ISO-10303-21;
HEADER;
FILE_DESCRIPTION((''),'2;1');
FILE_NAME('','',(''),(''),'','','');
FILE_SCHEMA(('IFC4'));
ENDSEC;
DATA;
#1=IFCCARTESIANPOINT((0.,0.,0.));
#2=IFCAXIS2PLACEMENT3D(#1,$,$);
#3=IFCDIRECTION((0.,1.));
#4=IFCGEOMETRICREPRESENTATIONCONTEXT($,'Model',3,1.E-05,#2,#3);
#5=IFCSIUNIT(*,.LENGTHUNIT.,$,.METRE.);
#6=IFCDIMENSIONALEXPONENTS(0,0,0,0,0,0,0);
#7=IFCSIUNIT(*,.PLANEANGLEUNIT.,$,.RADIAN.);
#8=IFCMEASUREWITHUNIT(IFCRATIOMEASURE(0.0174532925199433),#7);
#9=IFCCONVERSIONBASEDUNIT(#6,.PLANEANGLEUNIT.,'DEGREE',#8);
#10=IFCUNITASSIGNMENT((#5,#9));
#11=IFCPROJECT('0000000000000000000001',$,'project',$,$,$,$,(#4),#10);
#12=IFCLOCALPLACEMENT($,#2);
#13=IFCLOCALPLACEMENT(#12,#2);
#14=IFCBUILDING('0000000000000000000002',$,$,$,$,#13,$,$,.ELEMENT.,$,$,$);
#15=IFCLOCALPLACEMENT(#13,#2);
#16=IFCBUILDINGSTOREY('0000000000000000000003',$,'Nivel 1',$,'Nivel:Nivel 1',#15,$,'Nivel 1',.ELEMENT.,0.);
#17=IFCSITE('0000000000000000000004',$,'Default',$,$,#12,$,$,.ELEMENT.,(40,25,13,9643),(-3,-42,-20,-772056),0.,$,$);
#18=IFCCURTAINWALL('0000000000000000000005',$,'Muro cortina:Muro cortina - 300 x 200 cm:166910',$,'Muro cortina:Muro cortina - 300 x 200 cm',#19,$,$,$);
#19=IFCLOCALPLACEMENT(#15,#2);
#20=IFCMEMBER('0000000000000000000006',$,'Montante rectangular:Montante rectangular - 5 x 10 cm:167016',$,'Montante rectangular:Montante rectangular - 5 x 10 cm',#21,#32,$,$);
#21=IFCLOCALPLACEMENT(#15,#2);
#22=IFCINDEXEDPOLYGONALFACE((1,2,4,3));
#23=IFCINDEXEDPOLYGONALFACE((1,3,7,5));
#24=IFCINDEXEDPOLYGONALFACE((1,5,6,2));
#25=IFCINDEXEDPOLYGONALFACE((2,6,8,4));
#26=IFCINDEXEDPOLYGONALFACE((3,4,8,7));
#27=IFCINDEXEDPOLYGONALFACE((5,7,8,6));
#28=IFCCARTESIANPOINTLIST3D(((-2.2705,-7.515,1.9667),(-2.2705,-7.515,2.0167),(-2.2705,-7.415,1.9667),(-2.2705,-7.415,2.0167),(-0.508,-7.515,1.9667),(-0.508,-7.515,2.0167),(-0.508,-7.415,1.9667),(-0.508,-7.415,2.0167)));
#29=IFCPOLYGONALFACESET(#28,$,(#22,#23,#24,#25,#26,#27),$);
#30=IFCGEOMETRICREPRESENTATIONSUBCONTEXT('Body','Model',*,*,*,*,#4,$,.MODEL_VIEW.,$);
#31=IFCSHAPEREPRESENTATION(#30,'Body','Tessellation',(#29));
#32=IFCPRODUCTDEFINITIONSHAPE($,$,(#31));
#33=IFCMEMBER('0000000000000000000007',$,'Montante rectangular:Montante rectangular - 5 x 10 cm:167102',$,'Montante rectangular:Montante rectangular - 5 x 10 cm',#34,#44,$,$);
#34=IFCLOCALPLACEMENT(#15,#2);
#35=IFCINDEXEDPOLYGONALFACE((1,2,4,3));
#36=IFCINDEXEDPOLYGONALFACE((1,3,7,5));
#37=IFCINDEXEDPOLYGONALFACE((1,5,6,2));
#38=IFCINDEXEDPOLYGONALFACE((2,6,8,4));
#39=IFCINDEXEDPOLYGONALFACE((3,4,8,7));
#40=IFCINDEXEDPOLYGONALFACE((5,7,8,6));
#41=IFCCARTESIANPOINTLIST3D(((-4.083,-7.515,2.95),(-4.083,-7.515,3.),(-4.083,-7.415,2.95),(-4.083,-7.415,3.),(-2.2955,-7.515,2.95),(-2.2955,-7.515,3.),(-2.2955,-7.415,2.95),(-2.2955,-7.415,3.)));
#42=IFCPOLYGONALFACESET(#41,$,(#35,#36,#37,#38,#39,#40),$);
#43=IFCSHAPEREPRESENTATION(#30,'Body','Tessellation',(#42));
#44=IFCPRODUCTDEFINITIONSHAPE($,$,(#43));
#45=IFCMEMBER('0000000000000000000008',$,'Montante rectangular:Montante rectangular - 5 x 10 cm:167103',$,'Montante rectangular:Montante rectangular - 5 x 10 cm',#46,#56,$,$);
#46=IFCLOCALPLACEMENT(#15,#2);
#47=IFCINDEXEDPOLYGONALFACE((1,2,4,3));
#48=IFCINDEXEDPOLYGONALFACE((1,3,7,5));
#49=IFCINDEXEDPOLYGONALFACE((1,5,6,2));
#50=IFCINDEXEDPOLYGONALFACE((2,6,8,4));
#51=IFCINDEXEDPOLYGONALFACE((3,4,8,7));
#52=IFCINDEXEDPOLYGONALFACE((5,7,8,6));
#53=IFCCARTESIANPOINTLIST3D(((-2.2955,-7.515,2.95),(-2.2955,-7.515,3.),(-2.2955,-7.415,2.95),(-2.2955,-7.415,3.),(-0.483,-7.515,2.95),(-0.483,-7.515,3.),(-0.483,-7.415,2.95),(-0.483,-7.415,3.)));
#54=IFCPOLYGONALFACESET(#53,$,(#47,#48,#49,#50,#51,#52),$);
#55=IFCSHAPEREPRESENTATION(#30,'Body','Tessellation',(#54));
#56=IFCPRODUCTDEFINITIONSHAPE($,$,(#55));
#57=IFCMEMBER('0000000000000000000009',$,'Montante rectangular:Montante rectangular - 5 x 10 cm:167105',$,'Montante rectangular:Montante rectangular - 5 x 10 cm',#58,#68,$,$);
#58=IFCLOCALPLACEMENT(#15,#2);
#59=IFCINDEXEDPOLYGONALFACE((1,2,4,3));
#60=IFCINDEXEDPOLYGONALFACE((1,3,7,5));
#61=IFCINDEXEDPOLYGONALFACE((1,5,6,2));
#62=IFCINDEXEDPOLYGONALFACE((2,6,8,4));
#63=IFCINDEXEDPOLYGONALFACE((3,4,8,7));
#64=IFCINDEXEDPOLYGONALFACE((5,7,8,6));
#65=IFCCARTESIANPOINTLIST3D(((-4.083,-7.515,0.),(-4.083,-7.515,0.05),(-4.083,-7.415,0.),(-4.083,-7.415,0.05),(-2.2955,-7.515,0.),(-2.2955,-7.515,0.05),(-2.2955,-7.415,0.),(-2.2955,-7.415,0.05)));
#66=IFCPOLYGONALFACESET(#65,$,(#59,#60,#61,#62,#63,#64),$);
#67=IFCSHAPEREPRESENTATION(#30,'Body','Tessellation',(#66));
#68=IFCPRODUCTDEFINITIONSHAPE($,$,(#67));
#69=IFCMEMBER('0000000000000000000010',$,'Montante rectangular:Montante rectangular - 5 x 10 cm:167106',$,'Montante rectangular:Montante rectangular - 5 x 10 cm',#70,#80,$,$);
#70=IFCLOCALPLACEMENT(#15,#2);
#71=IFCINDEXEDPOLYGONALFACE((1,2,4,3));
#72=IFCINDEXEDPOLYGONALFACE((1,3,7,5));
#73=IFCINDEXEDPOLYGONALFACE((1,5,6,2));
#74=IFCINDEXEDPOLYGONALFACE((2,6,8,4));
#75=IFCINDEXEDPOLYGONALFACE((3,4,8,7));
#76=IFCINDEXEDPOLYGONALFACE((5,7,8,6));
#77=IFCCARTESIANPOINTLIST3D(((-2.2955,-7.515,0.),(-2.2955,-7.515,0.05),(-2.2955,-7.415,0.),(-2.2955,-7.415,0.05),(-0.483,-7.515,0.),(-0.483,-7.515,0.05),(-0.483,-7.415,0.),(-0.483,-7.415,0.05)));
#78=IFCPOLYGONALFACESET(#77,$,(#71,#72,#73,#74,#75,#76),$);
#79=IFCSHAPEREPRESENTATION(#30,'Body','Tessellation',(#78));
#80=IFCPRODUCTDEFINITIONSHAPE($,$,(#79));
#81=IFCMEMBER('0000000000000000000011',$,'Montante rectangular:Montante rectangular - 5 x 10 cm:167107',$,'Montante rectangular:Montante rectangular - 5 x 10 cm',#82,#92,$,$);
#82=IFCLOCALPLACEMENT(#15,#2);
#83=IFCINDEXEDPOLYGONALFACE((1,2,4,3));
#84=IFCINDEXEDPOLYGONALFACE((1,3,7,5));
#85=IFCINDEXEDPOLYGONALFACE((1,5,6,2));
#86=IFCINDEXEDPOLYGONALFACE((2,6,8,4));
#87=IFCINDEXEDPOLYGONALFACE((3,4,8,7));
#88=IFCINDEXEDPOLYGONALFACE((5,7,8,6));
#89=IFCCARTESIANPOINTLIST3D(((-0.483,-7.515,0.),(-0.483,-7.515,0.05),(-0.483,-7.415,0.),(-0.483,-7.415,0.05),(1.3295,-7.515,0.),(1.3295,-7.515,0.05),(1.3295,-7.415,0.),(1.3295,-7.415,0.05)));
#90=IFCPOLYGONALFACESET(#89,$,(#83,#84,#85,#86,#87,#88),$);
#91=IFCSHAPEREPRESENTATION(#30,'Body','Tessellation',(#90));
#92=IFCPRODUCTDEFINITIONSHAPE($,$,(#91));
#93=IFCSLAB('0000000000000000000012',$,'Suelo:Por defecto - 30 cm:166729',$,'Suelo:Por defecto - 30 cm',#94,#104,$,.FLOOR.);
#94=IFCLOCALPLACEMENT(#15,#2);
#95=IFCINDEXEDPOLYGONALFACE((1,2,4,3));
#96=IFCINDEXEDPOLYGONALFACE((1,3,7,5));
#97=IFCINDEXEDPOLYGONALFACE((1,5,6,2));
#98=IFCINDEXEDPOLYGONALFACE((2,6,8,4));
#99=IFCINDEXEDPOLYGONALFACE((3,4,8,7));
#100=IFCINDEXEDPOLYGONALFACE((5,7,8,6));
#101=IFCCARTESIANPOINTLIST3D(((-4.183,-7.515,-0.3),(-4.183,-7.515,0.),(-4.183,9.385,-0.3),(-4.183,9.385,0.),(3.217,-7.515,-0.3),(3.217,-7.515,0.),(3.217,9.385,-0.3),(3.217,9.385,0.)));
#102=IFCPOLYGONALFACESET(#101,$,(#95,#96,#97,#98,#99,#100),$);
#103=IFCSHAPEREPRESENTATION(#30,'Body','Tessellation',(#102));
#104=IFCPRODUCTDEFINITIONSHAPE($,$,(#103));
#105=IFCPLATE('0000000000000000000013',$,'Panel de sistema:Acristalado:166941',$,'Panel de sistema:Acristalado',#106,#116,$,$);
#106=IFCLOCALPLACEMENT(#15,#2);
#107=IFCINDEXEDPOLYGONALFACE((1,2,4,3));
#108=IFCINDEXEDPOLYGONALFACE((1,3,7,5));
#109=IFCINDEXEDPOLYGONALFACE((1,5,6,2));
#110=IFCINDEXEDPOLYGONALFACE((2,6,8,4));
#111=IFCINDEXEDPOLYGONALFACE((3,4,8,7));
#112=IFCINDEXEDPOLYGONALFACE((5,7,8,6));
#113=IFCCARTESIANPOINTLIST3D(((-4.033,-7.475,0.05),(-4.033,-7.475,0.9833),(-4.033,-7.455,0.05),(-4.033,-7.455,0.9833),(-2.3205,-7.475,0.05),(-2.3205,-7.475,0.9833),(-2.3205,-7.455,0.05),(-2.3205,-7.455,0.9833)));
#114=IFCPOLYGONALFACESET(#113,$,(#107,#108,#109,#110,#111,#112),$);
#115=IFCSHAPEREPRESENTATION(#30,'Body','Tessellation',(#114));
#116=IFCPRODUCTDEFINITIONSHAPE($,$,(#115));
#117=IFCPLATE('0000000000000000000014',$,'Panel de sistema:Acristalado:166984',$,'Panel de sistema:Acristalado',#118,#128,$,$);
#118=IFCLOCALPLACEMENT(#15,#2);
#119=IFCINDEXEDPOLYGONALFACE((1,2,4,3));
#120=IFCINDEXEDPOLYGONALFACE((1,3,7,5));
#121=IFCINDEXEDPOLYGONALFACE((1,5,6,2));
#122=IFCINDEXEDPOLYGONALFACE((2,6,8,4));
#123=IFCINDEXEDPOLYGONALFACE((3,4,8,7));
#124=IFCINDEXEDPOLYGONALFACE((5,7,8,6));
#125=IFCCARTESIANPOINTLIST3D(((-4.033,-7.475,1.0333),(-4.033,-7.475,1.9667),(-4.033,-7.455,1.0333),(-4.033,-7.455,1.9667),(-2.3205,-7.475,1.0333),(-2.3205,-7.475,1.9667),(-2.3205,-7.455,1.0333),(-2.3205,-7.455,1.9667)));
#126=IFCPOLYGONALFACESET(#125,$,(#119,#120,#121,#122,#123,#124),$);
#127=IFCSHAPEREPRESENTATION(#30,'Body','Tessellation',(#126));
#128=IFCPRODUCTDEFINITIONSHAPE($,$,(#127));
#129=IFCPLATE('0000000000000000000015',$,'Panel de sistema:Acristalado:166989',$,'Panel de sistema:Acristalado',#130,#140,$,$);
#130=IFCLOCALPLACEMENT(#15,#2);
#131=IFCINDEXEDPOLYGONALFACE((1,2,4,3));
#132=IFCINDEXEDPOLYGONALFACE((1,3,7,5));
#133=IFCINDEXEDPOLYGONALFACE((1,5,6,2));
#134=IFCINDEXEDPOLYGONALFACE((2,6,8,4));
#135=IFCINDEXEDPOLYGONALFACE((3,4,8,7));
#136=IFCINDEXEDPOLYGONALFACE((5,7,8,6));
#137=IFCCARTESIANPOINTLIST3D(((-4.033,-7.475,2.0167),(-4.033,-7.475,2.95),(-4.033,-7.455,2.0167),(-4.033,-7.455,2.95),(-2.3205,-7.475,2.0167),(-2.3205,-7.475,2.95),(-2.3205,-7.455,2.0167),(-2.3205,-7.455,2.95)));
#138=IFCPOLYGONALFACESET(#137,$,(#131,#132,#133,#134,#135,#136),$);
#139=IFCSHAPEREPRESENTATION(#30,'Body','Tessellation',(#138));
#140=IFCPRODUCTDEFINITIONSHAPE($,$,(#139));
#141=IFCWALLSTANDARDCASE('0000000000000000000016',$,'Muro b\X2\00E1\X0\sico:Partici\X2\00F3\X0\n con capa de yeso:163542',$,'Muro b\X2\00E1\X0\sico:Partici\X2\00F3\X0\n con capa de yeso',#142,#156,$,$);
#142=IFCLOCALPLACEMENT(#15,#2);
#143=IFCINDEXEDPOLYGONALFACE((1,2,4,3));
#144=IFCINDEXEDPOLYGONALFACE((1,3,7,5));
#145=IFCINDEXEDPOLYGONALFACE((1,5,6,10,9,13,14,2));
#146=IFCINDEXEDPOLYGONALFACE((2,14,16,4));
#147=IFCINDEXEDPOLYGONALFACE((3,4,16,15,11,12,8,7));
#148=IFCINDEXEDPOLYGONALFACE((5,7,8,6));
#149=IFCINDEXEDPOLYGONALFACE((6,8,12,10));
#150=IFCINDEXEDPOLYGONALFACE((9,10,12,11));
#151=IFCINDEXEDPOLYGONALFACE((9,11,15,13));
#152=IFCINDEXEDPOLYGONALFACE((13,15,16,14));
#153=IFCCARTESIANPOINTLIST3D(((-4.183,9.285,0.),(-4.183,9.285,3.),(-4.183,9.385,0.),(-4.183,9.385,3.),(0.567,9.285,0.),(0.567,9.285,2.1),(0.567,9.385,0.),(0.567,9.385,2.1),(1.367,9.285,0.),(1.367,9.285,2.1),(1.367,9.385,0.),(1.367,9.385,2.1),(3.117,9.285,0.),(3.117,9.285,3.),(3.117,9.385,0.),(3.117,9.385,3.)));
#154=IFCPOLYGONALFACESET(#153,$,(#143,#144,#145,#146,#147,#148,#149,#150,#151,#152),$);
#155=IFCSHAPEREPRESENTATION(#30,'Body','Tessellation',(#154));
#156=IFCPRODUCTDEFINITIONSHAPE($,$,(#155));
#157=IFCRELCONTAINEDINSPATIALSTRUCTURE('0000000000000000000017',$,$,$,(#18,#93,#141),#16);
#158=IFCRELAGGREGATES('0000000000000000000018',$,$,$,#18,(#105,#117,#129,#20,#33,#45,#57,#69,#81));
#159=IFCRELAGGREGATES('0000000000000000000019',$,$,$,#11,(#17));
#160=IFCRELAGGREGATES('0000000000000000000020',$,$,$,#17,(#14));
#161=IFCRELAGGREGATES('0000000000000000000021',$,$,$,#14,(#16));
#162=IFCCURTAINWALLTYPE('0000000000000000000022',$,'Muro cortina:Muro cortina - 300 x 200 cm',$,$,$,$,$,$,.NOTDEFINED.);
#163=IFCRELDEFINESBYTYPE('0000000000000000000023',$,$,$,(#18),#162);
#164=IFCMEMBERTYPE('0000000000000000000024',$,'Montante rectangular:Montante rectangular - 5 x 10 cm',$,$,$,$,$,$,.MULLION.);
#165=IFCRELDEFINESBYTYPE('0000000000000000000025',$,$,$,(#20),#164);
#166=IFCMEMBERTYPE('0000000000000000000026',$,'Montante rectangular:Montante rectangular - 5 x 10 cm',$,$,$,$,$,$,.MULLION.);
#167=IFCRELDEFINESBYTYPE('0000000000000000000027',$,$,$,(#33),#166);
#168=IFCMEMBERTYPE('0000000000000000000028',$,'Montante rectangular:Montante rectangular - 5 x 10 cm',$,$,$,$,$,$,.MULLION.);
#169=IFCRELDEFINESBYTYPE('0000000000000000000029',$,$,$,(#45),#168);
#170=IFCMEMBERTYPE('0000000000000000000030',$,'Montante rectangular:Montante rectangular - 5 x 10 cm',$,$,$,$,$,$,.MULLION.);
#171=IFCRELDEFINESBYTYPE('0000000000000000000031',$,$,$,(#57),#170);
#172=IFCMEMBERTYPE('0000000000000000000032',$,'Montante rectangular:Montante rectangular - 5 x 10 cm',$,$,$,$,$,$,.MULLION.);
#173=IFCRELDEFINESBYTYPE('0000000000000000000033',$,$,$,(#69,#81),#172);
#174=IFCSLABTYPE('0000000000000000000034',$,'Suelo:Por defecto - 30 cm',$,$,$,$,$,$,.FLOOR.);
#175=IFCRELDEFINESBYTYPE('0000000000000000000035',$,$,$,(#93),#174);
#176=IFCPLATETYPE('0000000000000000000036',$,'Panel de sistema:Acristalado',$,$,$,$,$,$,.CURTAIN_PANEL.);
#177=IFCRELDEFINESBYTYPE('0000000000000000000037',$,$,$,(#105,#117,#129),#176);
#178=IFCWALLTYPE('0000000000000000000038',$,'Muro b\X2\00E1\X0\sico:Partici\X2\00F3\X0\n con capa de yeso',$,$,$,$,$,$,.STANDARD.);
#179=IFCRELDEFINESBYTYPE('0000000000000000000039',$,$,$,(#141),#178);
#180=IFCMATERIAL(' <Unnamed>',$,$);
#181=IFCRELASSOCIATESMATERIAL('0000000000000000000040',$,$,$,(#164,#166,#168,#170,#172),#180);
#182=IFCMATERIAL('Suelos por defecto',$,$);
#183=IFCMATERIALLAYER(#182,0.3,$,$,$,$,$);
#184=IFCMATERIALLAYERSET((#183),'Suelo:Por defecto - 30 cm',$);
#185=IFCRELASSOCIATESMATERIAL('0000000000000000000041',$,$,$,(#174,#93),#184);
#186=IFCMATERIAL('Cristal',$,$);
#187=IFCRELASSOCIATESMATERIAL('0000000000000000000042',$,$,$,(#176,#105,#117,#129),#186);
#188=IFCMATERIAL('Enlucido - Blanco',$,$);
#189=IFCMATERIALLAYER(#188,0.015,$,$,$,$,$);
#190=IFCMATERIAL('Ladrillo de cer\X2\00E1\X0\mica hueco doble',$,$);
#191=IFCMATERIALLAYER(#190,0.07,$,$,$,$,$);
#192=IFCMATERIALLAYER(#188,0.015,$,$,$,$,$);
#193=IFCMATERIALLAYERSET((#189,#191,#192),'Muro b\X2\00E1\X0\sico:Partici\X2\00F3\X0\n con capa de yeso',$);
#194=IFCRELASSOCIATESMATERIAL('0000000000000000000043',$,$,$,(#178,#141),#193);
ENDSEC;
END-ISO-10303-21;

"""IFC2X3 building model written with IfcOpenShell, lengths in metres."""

from ifc_helpers import new_model, entity, si_unit, converted_unit, direction, frame, frame_2d, origin, origin_2d_with_axis, place, context, subcontext, project, spatial, rectangle, extrude, source, transform, mapped, material, layer, layer_set, layer_usage, type_object, type_shapes, element, aggregate, save


model = new_model("IFC2X3")

# Units and contexts
model_context = context("Model", 3, precision=1e-05, world=origin(), true_north=direction((0.0, 1.0)))
body_context = subcontext(model_context, "Body", "Model", "MODEL_VIEW")
ifc_project = project(units=[si_unit("LENGTHUNIT", "METRE"), converted_unit("PLANEANGLEUNIT", "DEGREE", entity("IfcRatioMeasure", 0.0174532925199433), si_unit("PLANEANGLEUNIT", "RADIAN"), dimensions=[0, 0, 0, 0, 0, 0, 0])], contexts=[model_context])

# Site, building, storey
site_placement = place(None, origin())
site = spatial("IfcSite", under=ifc_project, at=site_placement, Name="Default", CompositionType="ELEMENT", RefLatitude=(40, 25, 13, 9643), RefLongitude=(-3, -42, -20, -772056), RefElevation=0.0)
building_placement = place(site_placement, origin())
building = spatial("IfcBuilding", under=site, at=building_placement, CompositionType="ELEMENT")
storey_placement = place(building_placement, origin())
storey = spatial("IfcBuildingStorey", under=building, at=storey_placement, Name="Nivel 1", ObjectType="Nivel:Nivel 1", LongName="Nivel 1", CompositionType="ELEMENT", Elevation=0.0)

# Curtain wall, members
curtain_wall_type = type_object("IfcCurtainWallType", Name="Muro cortina:Muro cortina - 300 x 200 cm", PredefinedType="NOTDEFINED")
curtain_wall_placement = place(storey_placement, origin())
curtain_wall = element("IfcCurtainWall", 1, at=curtain_wall_placement, inside=storey, type_object=curtain_wall_type, Name="Muro cortina:Muro cortina - 300 x 200 cm:166910", ObjectType="Muro cortina:Muro cortina - 300 x 200 cm")
ifc_material_1 = material(Name=" <Unnamed>")
member_type_1 = type_object("IfcMemberType", Name="Montante rectangular:Montante rectangular - 5 x 10 cm", PredefinedType="MULLION", material=ifc_material_1)
shared_shape_1 = source(origin(), body_context, "Body", "SweptSolid", [
    extrude(rectangle(XDim=0.1, YDim=0.05, at=origin_2d_with_axis()), frame((0.0, 0.0, -1.7625), z_axis=(0.0, 0.0, 1.0), x_axis=(0.0, -1.0, 0.0)), (0.0, 0.0, 1.0), 1.7625),
])
type_shapes(member_type_1, [shared_shape_1])
member_1_placement = place(storey_placement, frame((-0.508, -7.465, 1.9917), z_axis=(1.0, 0.0, 0.0), x_axis=(0.0, 0.0, 1.0)))
member_1 = element("IfcMember", 2, at=member_1_placement, type_object=member_type_1, Name="Montante rectangular:Montante rectangular - 5 x 10 cm:167016", ObjectType="Montante rectangular:Montante rectangular - 5 x 10 cm", context=body_context, shape_type="MappedRepresentation", body=[
    mapped(shared_shape_1, transform((0.0, 0.0, 0.0), scale=1.0)),
])
member_type_2 = type_object("IfcMemberType", Name="Montante rectangular:Montante rectangular - 5 x 10 cm", PredefinedType="MULLION", material=ifc_material_1)
shared_shape_2 = source(origin(), body_context, "Body", "SweptSolid", [
    extrude(rectangle(XDim=0.1, YDim=0.05, at=origin_2d_with_axis()), frame((-0.025, 0.0, -1.7875), z_axis=(0.0, 0.0, 1.0), x_axis=(0.0, -1.0, 0.0)), (0.0, 0.0, 1.0), 1.7875),
])
type_shapes(member_type_2, [shared_shape_2])
member_2_placement = place(storey_placement, frame((-2.2955, -7.465, 3.0), z_axis=(1.0, 0.0, 0.0), x_axis=(0.0, 0.0, 1.0)))
member_2 = element("IfcMember", 3, at=member_2_placement, type_object=member_type_2, Name="Montante rectangular:Montante rectangular - 5 x 10 cm:167102", ObjectType="Montante rectangular:Montante rectangular - 5 x 10 cm", context=body_context, shape_type="MappedRepresentation", body=[
    mapped(shared_shape_2, transform((0.0, 0.0, 0.0), scale=1.0)),
])
member_type_3 = type_object("IfcMemberType", Name="Montante rectangular:Montante rectangular - 5 x 10 cm", PredefinedType="MULLION", material=ifc_material_1)
shared_shape_3 = source(origin(), body_context, "Body", "SweptSolid", [
    extrude(rectangle(XDim=0.1, YDim=0.05, at=origin_2d_with_axis()), frame((-0.025, 0.0, -1.8125), z_axis=(0.0, 0.0, 1.0), x_axis=(0.0, -1.0, 0.0)), (0.0, 0.0, 1.0), 1.8125),
])
type_shapes(member_type_3, [shared_shape_3])
member_3_placement = place(storey_placement, frame((-0.483, -7.465, 3.0), z_axis=(1.0, 0.0, 0.0), x_axis=(0.0, 0.0, 1.0)))
member_3 = element("IfcMember", 4, at=member_3_placement, type_object=member_type_3, Name="Montante rectangular:Montante rectangular - 5 x 10 cm:167103", ObjectType="Montante rectangular:Montante rectangular - 5 x 10 cm", context=body_context, shape_type="MappedRepresentation", body=[
    mapped(shared_shape_3, transform((0.0, 0.0, 0.0), scale=1.0)),
])
member_type_4 = type_object("IfcMemberType", Name="Montante rectangular:Montante rectangular - 5 x 10 cm", PredefinedType="MULLION", material=ifc_material_1)
shared_shape_4 = source(origin(), body_context, "Body", "SweptSolid", [
    extrude(rectangle(XDim=0.1, YDim=0.05, at=origin_2d_with_axis()), frame((-0.025, 0.0, -1.7875), z_axis=(0.0, 0.0, 1.0), x_axis=(0.0, -1.0, 0.0)), (0.0, 0.0, 1.0), 1.7875),
])
type_shapes(member_type_4, [shared_shape_4])
member_4_placement = place(storey_placement, frame((-4.083, -7.465, 0.0), z_axis=(-1.0, 0.0, 0.0), x_axis=(0.0, 0.0, -1.0)))
member_4 = element("IfcMember", 5, at=member_4_placement, type_object=member_type_4, Name="Montante rectangular:Montante rectangular - 5 x 10 cm:167105", ObjectType="Montante rectangular:Montante rectangular - 5 x 10 cm", context=body_context, shape_type="MappedRepresentation", body=[
    mapped(shared_shape_4, transform((0.0, 0.0, 0.0), scale=1.0)),
])
member_type_5 = type_object("IfcMemberType", Name="Montante rectangular:Montante rectangular - 5 x 10 cm", PredefinedType="MULLION", material=ifc_material_1)
shared_shape_5 = source(origin(), body_context, "Body", "SweptSolid", [
    extrude(rectangle(XDim=0.1, YDim=0.05, at=origin_2d_with_axis()), frame((-0.025, 0.0, -1.8125), z_axis=(0.0, 0.0, 1.0), x_axis=(0.0, -1.0, 0.0)), (0.0, 0.0, 1.0), 1.8125),
])
type_shapes(member_type_5, [shared_shape_5])
member_5_placement = place(storey_placement, frame((-2.2955, -7.465, 0.0), z_axis=(-1.0, 0.0, 0.0), x_axis=(0.0, 0.0, -1.0)))
member_5 = element("IfcMember", 6, at=member_5_placement, type_object=member_type_5, Name="Montante rectangular:Montante rectangular - 5 x 10 cm:167106", ObjectType="Montante rectangular:Montante rectangular - 5 x 10 cm", context=body_context, shape_type="MappedRepresentation", body=[
    mapped(shared_shape_5, transform((0.0, 0.0, 0.0), scale=1.0)),
])
member_6_placement = place(storey_placement, frame((-0.483, -7.465, 0.0), z_axis=(-1.0, 0.0, 0.0), x_axis=(0.0, 0.0, -1.0)))
member_6 = element("IfcMember", 7, at=member_6_placement, type_object=member_type_5, Name="Montante rectangular:Montante rectangular - 5 x 10 cm:167107", ObjectType="Montante rectangular:Montante rectangular - 5 x 10 cm", context=body_context, shape_type="MappedRepresentation", body=[
    mapped(shared_shape_5, transform((0.0, 0.0, 0.0), scale=1.0)),
])

# Slab
ifc_material_2 = material(Name="Suelos por defecto")
ifc_layer_1 = layer(ifc_material_2, 0.3)
ifc_layer_set_1 = layer_set([ifc_layer_1], Name="Suelo:Por defecto - 30 cm")
ifc_layer_usage_1 = layer_usage(ifc_layer_set_1, "AXIS3", "POSITIVE", 0.0)
slab_type = type_object("IfcSlabType", Name="Suelo:Por defecto - 30 cm", PredefinedType="FLOOR", material=ifc_layer_set_1)
slab_placement = place(storey_placement, origin())
element("IfcSlab", 8, at=slab_placement, inside=storey, type_object=slab_type, material=ifc_layer_usage_1, Name="Suelo:Por defecto - 30 cm:166729", ObjectType="Suelo:Por defecto - 30 cm", PredefinedType="FLOOR", context=body_context, shape_type="SweptSolid", body=[
    extrude(rectangle(XDim=16.9, YDim=7.4, at=origin_2d_with_axis()), frame((-0.483, 0.935, 0.0), z_axis=(0.0, 0.0, -1.0), x_axis=(0.0, 1.0, 0.0)), (0.0, 0.0, 1.0), 0.3),
])

# Plates
ifc_material_3 = material(Name="Cristal")
plate_type = type_object("IfcPlateType", Name="Panel de sistema:Acristalado", PredefinedType="CURTAIN_PANEL", material=ifc_material_3)
shared_shape_6 = source(origin(), body_context, "Body", "SweptSolid", [
    extrude(rectangle(XDim=0.02, YDim=1.7125, at=origin_2d_with_axis()), frame((0.0, 0.0, 0.0), z_axis=(0.0, 0.0, 1.0), x_axis=(0.0, 1.0, 0.0)), (0.0, 0.0, 1.0), 0.9333),
])
type_shapes(plate_type, [shared_shape_6])
plate_1_placement = place(curtain_wall_placement, frame((-3.1768, -7.465, 0.05)))
plate_1 = element("IfcPlate", 9, at=plate_1_placement, type_object=plate_type, material=ifc_material_3, Name="Panel de sistema:Acristalado:166941", ObjectType="Panel de sistema:Acristalado", context=body_context, shape_type="MappedRepresentation", body=[
    mapped(shared_shape_6, transform((0.0, 0.0, 0.0), scale=1.0)),
])
plate_2_placement = place(curtain_wall_placement, frame((-3.1768, -7.465, 1.0333)))
plate_2 = element("IfcPlate", 10, at=plate_2_placement, type_object=plate_type, material=ifc_material_3, Name="Panel de sistema:Acristalado:166984", ObjectType="Panel de sistema:Acristalado", context=body_context, shape_type="MappedRepresentation", body=[
    mapped(shared_shape_6, transform((0.0, 0.0, 0.0), scale=1.0)),
])
plate_3_placement = place(curtain_wall_placement, frame((-3.1768, -7.465, 2.0167)))
plate_3 = element("IfcPlate", 11, at=plate_3_placement, type_object=plate_type, material=ifc_material_3, Name="Panel de sistema:Acristalado:166989", ObjectType="Panel de sistema:Acristalado", context=body_context, shape_type="MappedRepresentation", body=[
    mapped(shared_shape_6, transform((0.0, 0.0, 0.0), scale=1.0)),
])
aggregate(curtain_wall, [plate_1, plate_2, plate_3, member_1, member_2, member_3, member_4, member_5, member_6])

# Wall, opening
ifc_material_4 = material(Name="Enlucido - Blanco")
ifc_layer_2 = layer(ifc_material_4, 0.015)
ifc_material_5 = material(Name="Ladrillo de cerámica hueco doble")
ifc_layer_3 = layer(ifc_material_5, 0.07)
ifc_layer_4 = layer(ifc_material_4, 0.015)
ifc_layer_set_2 = layer_set([ifc_layer_2, ifc_layer_3, ifc_layer_4], Name="Muro básico:Partición con capa de yeso")
ifc_layer_usage_2 = layer_usage(ifc_layer_set_2, "AXIS2", "NEGATIVE", 0.05)
wall_type = type_object("IfcWallType", Name="Muro básico:Partición con capa de yeso", PredefinedType="STANDARD", material=ifc_layer_set_2)
wall_1_placement = place(storey_placement, frame((-4.183, 9.335, 0.0)))
wall_1 = element("IfcWallStandardCase", 12, at=wall_1_placement, inside=storey, type_object=wall_type, material=ifc_layer_usage_2, Name="Muro básico:Partición con capa de yeso:163542", ObjectType="Muro básico:Partición con capa de yeso", context=body_context, shape_type="SweptSolid", body=[
    extrude(rectangle(XDim=7.3, YDim=0.1, at=frame_2d((3.65, 0.0), x_axis=(-1.0, 0.0))), origin(), (0.0, 0.0, 1.0), 3.0),
])
opening_1_placement = place(wall_1_placement, frame((5.55, 0.05, 0.0)))
element("IfcOpeningElement", 13, at=opening_1_placement, cuts=wall_1, ObjectType="Opening", context=body_context, shape_type="SweptSolid", body=[
    extrude(rectangle(XDim=2.1, YDim=0.8, at=frame_2d((1.05, 0.4), x_axis=(1.0, 0.0))), frame((0.0, 0.0, 0.0), z_axis=(0.0, -1.0, 0.0), x_axis=(0.0, 0.0, 1.0)), (0.0, 0.0, 1.0), 0.1),
])

save(model, "model.ifc")
